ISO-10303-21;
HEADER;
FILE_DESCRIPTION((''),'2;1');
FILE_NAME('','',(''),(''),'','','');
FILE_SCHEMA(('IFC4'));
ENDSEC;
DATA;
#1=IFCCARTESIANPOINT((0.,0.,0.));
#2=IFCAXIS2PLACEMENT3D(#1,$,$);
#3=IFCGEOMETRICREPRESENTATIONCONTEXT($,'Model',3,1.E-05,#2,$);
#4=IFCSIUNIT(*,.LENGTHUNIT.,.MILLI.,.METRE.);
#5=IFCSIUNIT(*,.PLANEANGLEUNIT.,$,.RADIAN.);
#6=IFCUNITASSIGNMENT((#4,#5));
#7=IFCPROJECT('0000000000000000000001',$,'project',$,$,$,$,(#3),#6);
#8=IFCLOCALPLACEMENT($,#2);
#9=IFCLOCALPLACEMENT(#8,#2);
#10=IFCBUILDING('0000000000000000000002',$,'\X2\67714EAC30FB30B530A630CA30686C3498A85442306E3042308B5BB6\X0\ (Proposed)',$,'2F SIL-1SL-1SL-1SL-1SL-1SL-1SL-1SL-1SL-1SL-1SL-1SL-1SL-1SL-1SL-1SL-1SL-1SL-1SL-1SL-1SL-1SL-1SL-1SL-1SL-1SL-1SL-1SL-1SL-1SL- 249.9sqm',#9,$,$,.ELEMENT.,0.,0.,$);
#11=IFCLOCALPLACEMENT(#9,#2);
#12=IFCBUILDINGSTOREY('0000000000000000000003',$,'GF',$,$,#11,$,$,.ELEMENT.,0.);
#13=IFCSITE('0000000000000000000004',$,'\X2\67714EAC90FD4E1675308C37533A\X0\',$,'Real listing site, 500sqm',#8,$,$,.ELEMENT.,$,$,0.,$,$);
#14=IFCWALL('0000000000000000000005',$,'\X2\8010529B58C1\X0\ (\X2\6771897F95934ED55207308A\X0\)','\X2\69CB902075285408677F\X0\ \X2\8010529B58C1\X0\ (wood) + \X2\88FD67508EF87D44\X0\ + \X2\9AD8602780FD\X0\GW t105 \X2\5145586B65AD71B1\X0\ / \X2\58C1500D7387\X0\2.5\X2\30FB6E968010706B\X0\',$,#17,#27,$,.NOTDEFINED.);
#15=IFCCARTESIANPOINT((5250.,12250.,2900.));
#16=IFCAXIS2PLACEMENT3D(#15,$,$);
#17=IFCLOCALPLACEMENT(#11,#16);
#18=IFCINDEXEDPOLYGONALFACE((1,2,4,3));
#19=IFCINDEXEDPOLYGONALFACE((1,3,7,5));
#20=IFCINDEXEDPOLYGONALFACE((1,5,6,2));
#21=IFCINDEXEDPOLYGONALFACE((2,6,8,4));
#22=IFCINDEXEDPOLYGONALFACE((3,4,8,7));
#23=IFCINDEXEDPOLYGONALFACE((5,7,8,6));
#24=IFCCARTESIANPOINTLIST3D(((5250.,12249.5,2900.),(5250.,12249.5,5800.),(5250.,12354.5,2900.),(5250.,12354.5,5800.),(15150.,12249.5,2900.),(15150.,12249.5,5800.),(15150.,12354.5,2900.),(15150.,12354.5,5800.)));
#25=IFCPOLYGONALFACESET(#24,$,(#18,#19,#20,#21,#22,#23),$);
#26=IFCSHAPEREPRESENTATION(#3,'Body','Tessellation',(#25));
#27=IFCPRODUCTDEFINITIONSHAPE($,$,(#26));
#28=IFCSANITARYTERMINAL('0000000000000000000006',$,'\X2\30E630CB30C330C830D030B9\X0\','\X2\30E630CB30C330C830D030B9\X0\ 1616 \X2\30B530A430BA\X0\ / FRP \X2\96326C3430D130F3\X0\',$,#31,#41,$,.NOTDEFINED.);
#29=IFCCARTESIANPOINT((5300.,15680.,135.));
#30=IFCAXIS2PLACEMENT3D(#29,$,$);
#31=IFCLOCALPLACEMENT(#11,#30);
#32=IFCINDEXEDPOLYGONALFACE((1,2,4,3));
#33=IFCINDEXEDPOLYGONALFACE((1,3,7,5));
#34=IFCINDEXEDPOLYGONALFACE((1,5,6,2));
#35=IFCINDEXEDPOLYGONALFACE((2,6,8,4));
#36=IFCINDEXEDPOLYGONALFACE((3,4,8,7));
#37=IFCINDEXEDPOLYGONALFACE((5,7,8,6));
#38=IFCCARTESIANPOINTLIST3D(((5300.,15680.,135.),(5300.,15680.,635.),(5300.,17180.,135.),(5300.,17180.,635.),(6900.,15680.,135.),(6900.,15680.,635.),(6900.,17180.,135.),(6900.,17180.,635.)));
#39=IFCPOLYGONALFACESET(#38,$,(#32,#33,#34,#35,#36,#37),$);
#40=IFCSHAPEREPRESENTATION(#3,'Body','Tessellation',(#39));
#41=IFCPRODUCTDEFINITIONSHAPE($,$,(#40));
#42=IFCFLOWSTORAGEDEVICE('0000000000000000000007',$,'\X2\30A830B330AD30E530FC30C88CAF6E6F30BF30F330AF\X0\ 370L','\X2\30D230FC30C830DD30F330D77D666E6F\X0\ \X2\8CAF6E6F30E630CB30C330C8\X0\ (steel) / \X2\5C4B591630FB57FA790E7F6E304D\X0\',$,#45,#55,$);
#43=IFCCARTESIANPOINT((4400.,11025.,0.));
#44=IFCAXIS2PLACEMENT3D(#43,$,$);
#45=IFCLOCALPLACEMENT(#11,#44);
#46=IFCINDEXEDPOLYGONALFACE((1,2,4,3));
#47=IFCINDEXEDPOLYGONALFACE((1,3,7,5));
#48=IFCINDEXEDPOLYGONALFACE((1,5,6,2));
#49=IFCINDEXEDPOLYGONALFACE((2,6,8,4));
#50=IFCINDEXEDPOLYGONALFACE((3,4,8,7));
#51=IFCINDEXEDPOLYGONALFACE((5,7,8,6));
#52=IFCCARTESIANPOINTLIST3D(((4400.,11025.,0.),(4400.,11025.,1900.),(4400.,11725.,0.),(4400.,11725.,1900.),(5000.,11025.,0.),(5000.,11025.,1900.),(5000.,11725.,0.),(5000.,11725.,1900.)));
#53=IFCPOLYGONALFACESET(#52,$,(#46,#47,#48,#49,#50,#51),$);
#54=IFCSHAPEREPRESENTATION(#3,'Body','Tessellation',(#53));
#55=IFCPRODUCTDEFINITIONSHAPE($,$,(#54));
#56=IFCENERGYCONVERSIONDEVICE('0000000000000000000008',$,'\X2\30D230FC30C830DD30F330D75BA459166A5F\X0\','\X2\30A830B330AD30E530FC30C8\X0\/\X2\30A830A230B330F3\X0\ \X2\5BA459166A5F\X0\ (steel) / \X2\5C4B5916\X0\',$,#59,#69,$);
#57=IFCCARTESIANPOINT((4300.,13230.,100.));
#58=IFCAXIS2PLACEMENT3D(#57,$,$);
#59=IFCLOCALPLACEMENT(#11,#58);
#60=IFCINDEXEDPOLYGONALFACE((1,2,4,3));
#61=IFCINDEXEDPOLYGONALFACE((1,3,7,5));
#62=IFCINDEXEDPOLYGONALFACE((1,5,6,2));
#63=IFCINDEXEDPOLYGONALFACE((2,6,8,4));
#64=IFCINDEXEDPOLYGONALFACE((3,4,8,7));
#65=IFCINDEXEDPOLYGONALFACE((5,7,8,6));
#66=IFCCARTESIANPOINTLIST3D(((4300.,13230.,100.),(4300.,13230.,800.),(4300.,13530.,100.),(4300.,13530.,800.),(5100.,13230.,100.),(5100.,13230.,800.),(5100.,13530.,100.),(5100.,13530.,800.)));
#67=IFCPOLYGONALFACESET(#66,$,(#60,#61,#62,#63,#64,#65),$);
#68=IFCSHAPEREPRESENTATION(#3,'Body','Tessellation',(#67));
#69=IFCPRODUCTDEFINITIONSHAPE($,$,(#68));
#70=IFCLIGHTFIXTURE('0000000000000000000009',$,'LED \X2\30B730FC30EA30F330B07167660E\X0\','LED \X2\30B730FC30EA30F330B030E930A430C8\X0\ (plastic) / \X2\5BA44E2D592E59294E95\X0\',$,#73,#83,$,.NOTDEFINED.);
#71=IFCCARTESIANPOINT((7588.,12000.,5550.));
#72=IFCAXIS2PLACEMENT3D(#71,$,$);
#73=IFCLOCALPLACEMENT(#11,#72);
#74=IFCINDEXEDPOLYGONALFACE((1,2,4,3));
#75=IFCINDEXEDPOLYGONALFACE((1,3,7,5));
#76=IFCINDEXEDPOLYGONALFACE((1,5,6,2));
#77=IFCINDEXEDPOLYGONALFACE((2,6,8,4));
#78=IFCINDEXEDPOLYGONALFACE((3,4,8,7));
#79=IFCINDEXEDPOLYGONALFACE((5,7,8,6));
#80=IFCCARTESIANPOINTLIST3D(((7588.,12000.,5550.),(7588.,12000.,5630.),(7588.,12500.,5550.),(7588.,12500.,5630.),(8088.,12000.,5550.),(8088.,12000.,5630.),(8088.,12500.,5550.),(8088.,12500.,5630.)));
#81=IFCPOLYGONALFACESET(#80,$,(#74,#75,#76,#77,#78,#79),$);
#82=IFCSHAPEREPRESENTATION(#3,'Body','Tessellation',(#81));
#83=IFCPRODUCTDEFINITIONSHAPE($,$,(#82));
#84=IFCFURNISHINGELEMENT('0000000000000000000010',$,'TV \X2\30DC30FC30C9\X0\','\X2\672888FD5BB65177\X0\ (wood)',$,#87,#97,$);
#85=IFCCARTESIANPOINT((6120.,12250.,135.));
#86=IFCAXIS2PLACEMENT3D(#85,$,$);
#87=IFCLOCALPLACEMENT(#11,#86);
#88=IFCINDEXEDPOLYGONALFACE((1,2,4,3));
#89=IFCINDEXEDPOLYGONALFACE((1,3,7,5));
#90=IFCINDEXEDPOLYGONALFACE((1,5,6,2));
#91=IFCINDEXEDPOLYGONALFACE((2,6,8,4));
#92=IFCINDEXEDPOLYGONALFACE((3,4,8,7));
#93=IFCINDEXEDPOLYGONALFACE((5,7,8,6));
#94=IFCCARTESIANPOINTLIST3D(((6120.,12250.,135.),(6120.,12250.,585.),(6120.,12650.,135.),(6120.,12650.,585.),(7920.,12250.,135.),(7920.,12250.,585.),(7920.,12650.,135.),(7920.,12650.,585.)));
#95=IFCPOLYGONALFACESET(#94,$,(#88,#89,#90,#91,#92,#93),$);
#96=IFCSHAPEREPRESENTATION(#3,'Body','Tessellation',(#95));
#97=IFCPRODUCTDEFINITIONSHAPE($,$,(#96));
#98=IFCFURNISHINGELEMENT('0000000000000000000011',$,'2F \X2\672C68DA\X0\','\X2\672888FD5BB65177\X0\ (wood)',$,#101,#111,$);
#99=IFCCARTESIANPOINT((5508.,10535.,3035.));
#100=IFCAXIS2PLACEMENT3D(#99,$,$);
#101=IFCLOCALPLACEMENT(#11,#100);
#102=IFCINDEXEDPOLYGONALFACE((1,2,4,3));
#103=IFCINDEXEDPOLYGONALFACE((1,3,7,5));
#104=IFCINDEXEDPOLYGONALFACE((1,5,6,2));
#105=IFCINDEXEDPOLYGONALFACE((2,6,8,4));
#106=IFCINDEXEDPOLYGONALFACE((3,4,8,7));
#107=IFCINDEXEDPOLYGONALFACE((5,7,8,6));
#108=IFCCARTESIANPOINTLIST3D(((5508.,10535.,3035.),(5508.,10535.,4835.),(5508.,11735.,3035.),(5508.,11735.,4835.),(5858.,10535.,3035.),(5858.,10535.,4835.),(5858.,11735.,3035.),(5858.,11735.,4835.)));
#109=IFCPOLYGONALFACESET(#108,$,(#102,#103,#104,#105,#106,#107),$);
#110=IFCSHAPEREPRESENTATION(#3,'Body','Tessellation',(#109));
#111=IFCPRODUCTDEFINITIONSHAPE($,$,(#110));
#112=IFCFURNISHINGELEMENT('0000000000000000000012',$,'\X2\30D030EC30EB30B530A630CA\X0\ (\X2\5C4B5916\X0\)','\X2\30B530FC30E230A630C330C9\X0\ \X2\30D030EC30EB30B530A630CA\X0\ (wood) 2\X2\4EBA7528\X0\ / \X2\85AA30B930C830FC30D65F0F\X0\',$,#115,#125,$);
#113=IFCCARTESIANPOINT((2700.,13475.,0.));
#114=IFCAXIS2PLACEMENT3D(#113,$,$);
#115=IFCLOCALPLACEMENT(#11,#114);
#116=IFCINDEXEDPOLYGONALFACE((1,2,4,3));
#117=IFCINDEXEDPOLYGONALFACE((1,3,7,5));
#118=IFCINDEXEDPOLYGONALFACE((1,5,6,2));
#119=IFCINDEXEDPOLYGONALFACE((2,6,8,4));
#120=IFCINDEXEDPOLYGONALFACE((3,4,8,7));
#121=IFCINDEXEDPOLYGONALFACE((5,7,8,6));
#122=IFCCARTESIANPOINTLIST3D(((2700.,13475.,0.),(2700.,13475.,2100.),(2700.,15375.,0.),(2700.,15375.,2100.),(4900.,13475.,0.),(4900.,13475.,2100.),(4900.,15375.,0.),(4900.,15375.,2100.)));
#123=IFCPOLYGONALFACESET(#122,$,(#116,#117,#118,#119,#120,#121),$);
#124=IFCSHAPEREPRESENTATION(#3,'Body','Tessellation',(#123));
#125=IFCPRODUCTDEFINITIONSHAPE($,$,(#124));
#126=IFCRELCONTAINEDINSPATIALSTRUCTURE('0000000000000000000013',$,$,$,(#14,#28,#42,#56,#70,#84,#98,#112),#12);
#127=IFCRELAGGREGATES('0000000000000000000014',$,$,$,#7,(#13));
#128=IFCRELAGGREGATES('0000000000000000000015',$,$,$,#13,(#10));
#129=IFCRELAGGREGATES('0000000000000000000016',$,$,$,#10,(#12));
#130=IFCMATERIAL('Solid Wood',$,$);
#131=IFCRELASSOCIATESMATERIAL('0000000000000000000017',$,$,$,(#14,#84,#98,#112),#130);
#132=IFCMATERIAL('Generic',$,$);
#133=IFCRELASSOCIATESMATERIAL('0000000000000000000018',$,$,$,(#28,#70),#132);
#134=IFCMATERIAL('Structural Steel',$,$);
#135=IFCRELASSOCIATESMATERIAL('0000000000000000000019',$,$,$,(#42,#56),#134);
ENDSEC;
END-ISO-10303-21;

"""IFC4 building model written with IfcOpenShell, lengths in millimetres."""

from ifc_helpers import new_model, si_unit, frame, frame_2d, origin, place, context, project, spatial, rectangle, extrude, material, element, save


model = new_model("IFC4")

# Units and contexts
model_context = context("Model", 3, precision=1e-05, world=origin())
ifc_project = project(units=[si_unit("LENGTHUNIT", "METRE", prefix="MILLI"), si_unit("PLANEANGLEUNIT", "RADIAN")], contexts=[model_context])

# Site, building, storey
site_placement = place(None, origin())
site = spatial("IfcSite", under=ifc_project, at=site_placement, Name="東京都世田谷区", ObjectType="Real listing site, 500sqm", CompositionType="ELEMENT", RefElevation=0.0)
building_placement = place(site_placement, origin())
building = spatial("IfcBuilding", under=site, at=building_placement, Name="東京・サウナと水風呂のある家 (Proposed)", ObjectType="2F SIL-1SL-1SL-1SL-1SL-1SL-1SL-1SL-1SL-1SL-1SL-1SL-1SL-1SL-1SL-1SL-1SL-1SL-1SL-1SL-1SL-1SL-1SL-1SL-1SL-1SL-1SL-1SL-1SL-1SL- 249.9sqm", CompositionType="ELEMENT", ElevationOfRefHeight=0.0, ElevationOfTerrain=0.0)
storey_placement = place(building_placement, origin())
storey = spatial("IfcBuildingStorey", under=building, at=storey_placement, Name="GF", CompositionType="ELEMENT", Elevation=0.0)

# Shared definitions
ifc_material_1 = material(Name="Solid Wood")

# Wall
wall_1_placement = place(storey_placement, frame((5250.0, 12250.0, 2900.0)))
element("IfcWall", 1, at=wall_1_placement, inside=storey, material=ifc_material_1, Name="耐力壁 (東西間仕切り)", Description="構造用合板 耐力壁 (wood) + 製材軸組 + 高性能GW t105 充填断熱 / 壁倍率2.5・準耐火", PredefinedType="NOTDEFINED", context=model_context, shape_type="SweptSolid", body=[
    extrude(rectangle(XDim=9900.0, YDim=105.0, at=frame_2d((4950.0, 52.0))), frame((5250.0, 12250.0, 2900.0)), (0.0, 0.0, 1.0), 2900.0),
])

# Sanitary terminal
ifc_material_2 = material(Name="Generic")
sanitary_terminal_placement = place(storey_placement, frame((5300.0, 15680.0, 135.0)))
element("IfcSanitaryTerminal", 2, at=sanitary_terminal_placement, inside=storey, material=ifc_material_2, Name="ユニットバス", Description="ユニットバス 1616 サイズ / FRP 防水パン", PredefinedType="NOTDEFINED", context=model_context, shape_type="SweptSolid", body=[
    extrude(rectangle(XDim=1600.0, YDim=1500.0, at=frame_2d((800.0, 750.0))), frame((5300.0, 15680.0, 135.0)), (0.0, 0.0, 1.0), 500.0),
])

# Flow storage device
ifc_material_3 = material(Name="Structural Steel")
flow_storage_device_placement = place(storey_placement, frame((4400.0, 11025.0, 0.0)))
element("IfcFlowStorageDevice", 3, at=flow_storage_device_placement, inside=storey, material=ifc_material_3, Name="エコキュート貯湯タンク 370L", Description="ヒートポンプ給湯 貯湯ユニット (steel) / 屋外・基礎置き", context=model_context, shape_type="SweptSolid", body=[
    extrude(rectangle(XDim=600.0, YDim=700.0, at=frame_2d((300.0, 350.0))), frame((4400.0, 11025.0, 0.0)), (0.0, 0.0, 1.0), 1900.0),
])

# Energy conversion device
energy_conversion_device_placement = place(storey_placement, frame((4300.0, 13230.0, 100.0)))
element("IfcEnergyConversionDevice", 4, at=energy_conversion_device_placement, inside=storey, material=ifc_material_3, Name="ヒートポンプ室外機", Description="エコキュート/エアコン 室外機 (steel) / 屋外", context=model_context, shape_type="SweptSolid", body=[
    extrude(rectangle(XDim=800.0, YDim=300.0, at=frame_2d((400.0, 150.0))), frame((4300.0, 13230.0, 100.0)), (0.0, 0.0, 1.0), 700.0),
])

# Light fixture
light_fixture_placement = place(storey_placement, frame((7588.0, 12000.0, 5550.0)))
element("IfcLightFixture", 5, at=light_fixture_placement, inside=storey, material=ifc_material_2, Name="LED シーリング照明", Description="LED シーリングライト (plastic) / 室中央天井", PredefinedType="NOTDEFINED", context=model_context, shape_type="SweptSolid", body=[
    extrude(rectangle(XDim=500.0, YDim=500.0, at=frame_2d((250.0, 250.0))), frame((7588.0, 12000.0, 5550.0)), (0.0, 0.0, 1.0), 80.0),
])

# Furnishing elements
furnishing_1_placement = place(storey_placement, frame((6120.0, 12250.0, 135.0)))
element("IfcFurnishingElement", 6, at=furnishing_1_placement, inside=storey, material=ifc_material_1, Name="TV ボード", Description="木製家具 (wood)", context=model_context, shape_type="SweptSolid", body=[
    extrude(rectangle(XDim=1800.0, YDim=400.0, at=frame_2d((900.0, 200.0))), frame((6120.0, 12250.0, 135.0)), (0.0, 0.0, 1.0), 450.0),
])
furnishing_2_placement = place(storey_placement, frame((5508.0, 10535.0, 3035.0)))
element("IfcFurnishingElement", 7, at=furnishing_2_placement, inside=storey, material=ifc_material_1, Name="2F 本棚", Description="木製家具 (wood)", context=model_context, shape_type="SweptSolid", body=[
    extrude(rectangle(XDim=350.0, YDim=1200.0, at=frame_2d((175.0, 600.0))), frame((5508.0, 10535.0, 3035.0)), (0.0, 0.0, 1.0), 1800.0),
])
furnishing_3_placement = place(storey_placement, frame((2700.0, 13475.0, 0.0)))
element("IfcFurnishingElement", 8, at=furnishing_3_placement, inside=storey, material=ifc_material_1, Name="バレルサウナ (屋外)", Description="サーモウッド バレルサウナ (wood) 2人用 / 薪ストーブ式", context=model_context, shape_type="SweptSolid", body=[
    extrude(rectangle(XDim=2200.0, YDim=1900.0, at=frame_2d((1100.0, 950.0))), frame((2700.0, 13475.0, 0.0)), (0.0, 0.0, 1.0), 2100.0),
])

save(model, "model.ifc")
